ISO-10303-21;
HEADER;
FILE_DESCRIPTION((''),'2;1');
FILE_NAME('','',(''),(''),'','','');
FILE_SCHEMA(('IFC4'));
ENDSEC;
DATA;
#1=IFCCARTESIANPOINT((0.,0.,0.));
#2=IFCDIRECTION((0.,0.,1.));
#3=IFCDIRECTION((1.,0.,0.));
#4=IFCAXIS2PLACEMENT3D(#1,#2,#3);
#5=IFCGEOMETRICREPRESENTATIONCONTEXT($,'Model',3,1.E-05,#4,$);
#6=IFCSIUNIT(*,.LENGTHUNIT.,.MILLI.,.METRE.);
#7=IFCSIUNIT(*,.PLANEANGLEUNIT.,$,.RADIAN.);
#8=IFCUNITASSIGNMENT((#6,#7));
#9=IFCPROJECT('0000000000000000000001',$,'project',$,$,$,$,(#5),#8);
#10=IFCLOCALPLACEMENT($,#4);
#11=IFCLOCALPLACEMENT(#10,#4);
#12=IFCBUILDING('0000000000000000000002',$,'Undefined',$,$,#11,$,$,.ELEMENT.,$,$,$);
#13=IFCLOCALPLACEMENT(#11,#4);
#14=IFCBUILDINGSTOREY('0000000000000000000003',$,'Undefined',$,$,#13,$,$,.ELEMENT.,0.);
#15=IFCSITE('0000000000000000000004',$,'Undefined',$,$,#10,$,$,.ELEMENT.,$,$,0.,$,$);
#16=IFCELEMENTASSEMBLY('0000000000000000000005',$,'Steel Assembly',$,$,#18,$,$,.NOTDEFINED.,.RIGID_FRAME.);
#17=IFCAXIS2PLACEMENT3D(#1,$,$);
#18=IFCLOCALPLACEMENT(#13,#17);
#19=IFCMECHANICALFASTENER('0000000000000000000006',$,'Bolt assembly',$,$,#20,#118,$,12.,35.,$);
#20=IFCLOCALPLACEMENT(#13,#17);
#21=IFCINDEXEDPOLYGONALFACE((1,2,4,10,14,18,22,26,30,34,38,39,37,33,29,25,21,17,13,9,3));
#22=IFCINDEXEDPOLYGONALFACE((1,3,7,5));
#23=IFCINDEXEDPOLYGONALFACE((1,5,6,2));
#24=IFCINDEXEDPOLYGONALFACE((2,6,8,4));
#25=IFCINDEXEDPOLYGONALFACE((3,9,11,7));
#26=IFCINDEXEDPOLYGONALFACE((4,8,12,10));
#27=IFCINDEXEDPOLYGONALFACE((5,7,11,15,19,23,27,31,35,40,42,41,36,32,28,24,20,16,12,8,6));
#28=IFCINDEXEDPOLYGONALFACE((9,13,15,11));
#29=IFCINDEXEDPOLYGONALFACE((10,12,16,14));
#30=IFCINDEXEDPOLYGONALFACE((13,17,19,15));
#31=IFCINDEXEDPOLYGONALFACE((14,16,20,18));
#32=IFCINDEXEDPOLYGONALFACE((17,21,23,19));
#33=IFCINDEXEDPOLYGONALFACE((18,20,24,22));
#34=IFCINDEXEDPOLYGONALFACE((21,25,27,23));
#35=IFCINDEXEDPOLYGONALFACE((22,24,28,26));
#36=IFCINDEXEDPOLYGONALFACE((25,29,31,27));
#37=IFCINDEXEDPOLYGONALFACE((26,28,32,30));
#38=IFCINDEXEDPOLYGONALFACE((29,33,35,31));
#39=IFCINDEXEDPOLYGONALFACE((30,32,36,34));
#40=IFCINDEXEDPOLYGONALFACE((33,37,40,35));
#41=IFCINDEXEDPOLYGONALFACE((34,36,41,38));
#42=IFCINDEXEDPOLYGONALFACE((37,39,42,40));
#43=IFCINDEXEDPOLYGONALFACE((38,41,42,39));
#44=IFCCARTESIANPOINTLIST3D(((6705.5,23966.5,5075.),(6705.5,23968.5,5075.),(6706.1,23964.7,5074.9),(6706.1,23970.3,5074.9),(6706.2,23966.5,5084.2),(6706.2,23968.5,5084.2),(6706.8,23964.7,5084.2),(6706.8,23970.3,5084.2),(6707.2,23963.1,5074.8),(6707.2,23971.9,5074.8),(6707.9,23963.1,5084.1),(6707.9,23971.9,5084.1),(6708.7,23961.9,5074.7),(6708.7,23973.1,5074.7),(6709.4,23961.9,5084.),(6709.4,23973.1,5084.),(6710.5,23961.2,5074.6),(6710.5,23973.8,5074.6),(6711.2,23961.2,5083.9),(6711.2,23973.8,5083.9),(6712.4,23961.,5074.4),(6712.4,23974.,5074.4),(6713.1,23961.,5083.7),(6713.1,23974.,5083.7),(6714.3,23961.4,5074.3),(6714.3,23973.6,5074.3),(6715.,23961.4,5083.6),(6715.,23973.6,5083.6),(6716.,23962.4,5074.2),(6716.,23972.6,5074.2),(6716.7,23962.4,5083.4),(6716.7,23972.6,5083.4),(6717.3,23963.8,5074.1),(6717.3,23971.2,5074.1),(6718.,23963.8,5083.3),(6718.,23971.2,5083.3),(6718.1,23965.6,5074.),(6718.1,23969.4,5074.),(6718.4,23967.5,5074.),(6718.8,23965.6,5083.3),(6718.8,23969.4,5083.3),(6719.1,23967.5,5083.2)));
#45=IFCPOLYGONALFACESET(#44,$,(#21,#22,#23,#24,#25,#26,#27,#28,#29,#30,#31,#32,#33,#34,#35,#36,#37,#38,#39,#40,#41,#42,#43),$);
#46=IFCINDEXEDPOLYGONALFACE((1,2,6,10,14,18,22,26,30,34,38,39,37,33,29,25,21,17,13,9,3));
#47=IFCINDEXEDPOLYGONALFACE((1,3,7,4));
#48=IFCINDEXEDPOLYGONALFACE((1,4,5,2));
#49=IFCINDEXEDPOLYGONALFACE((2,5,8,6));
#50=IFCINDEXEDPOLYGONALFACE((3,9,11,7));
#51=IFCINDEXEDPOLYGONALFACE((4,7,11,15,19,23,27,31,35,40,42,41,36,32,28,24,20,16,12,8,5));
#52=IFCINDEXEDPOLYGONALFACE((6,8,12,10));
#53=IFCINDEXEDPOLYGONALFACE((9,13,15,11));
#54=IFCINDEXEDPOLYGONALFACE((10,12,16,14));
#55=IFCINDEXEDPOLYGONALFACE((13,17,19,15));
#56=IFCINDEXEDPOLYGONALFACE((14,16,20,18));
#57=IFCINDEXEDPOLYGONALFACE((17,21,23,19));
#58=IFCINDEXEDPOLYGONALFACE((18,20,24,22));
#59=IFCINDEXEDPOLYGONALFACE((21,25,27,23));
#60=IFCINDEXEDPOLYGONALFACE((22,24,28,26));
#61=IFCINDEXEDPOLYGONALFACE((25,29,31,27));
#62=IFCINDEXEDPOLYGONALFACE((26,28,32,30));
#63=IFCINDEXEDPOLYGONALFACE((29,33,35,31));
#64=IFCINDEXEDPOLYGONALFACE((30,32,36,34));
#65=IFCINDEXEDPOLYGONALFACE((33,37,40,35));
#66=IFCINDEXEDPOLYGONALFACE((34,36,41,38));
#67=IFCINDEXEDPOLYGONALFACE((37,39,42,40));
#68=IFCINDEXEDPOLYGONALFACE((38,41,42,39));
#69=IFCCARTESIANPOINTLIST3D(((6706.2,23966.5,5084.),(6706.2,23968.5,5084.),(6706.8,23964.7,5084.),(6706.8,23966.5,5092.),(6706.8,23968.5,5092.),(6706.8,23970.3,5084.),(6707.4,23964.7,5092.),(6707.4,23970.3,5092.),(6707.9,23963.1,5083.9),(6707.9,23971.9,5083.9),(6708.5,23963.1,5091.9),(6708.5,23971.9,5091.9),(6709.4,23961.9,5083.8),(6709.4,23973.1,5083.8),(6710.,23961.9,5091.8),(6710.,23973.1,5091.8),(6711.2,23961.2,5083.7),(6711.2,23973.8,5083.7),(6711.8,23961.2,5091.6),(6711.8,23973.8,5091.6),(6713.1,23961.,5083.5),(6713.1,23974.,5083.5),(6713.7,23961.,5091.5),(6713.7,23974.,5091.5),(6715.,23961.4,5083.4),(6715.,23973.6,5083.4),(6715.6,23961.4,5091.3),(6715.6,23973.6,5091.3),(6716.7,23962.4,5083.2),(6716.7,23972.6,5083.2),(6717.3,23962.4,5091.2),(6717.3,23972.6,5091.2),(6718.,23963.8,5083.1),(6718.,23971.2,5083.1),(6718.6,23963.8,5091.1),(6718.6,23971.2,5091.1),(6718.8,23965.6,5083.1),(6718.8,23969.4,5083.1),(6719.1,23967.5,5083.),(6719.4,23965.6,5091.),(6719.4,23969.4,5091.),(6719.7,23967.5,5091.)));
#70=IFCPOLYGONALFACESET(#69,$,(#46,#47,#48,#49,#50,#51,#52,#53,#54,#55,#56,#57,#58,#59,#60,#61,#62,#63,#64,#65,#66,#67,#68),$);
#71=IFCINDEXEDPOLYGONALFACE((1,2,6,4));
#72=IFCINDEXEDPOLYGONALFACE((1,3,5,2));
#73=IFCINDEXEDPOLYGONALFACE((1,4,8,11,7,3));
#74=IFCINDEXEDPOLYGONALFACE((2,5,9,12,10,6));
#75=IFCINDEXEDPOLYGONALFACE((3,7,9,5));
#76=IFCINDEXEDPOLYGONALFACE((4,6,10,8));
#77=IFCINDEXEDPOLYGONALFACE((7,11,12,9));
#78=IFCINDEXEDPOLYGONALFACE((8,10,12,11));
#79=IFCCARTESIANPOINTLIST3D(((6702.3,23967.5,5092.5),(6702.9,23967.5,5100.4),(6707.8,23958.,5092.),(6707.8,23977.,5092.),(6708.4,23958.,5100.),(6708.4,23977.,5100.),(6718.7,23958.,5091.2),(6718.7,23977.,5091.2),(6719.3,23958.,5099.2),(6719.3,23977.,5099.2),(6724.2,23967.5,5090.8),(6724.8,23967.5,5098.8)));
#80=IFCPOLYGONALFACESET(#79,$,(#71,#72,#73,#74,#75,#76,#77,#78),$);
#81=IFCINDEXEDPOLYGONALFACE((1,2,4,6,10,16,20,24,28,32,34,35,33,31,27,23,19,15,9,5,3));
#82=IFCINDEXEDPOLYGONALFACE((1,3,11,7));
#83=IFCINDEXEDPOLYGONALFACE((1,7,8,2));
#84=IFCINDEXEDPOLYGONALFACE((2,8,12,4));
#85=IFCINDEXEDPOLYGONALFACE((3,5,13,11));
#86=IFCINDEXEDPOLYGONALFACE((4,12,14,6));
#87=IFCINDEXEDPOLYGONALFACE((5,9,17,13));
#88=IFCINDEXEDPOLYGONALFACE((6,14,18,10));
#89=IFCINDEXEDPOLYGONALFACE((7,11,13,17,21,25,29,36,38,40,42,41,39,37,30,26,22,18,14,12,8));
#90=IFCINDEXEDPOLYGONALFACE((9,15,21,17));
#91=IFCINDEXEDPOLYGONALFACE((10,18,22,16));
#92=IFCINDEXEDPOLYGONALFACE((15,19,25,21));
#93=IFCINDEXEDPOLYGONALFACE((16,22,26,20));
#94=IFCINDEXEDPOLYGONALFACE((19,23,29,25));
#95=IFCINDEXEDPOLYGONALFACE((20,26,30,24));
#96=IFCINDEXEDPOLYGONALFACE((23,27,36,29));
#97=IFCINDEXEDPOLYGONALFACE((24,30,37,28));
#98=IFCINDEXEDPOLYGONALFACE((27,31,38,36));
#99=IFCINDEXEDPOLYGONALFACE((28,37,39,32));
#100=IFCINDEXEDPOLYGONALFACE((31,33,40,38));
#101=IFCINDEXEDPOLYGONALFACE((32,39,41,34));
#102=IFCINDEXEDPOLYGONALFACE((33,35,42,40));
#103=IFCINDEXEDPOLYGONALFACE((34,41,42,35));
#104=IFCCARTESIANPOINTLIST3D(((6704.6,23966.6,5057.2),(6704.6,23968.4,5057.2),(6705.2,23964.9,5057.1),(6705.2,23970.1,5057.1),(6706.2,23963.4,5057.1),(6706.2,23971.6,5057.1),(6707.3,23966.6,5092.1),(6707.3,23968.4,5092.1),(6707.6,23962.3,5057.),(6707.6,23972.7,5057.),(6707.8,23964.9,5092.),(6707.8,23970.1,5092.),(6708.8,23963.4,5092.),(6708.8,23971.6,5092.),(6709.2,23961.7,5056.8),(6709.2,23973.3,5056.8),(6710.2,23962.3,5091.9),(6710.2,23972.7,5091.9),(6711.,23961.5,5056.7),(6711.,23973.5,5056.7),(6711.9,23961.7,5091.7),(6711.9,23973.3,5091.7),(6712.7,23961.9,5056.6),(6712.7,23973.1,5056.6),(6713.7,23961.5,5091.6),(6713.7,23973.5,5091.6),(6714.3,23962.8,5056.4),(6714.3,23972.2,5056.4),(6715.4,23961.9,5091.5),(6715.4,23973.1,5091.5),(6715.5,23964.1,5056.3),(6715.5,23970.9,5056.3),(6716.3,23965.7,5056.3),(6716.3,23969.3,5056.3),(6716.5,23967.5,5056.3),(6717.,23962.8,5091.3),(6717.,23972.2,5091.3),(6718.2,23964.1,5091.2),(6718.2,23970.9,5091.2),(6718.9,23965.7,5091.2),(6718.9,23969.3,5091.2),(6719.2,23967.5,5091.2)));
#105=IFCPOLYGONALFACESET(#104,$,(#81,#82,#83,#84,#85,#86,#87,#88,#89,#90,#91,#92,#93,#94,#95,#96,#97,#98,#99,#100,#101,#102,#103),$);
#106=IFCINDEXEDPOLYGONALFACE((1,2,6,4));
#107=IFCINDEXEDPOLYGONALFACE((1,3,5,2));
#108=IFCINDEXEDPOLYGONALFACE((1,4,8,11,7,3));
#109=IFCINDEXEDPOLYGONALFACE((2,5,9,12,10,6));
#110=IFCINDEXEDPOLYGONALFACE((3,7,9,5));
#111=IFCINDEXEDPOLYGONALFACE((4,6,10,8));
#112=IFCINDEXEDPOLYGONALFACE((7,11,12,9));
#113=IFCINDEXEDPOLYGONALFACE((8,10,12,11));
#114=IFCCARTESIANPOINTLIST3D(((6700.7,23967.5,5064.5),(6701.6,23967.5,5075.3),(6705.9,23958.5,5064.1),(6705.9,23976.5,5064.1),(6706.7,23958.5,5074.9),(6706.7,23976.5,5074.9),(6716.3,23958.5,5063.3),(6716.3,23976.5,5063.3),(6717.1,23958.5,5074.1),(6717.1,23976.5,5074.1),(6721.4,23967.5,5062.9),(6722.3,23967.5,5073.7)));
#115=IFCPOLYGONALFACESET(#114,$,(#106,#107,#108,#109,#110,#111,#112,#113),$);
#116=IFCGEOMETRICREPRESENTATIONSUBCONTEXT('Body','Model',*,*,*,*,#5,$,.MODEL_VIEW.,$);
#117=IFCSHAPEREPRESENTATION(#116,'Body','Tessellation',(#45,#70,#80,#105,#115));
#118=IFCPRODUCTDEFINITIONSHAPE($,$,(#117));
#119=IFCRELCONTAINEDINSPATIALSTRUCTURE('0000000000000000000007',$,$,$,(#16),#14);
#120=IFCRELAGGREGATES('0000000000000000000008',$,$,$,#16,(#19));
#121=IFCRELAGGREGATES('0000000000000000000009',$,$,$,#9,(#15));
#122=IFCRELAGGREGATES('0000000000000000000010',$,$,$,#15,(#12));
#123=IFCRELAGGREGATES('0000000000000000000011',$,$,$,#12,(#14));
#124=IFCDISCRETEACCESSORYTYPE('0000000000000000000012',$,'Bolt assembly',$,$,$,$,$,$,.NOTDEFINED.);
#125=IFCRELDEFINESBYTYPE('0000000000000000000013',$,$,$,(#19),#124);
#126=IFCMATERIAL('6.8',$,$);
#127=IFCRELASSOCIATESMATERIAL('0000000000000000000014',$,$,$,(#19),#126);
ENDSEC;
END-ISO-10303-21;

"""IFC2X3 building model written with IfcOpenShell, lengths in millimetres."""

from ifc_helpers import new_model, si_unit, frame, origin_with_axes, origin_2d_with_axis, place, context, subcontext, project, spatial, polyline, circle, outline, extrude, source, transform, mapped, material, type_object, element, aggregate, save


model = new_model("IFC2X3")

# Units and contexts
model_context = context("Model", 3, precision=1e-05, world=origin_with_axes())
body_context = subcontext(model_context, "Body", "Model", "MODEL_VIEW")
ifc_project = project(units=[si_unit("LENGTHUNIT", "METRE", prefix="MILLI"), si_unit("PLANEANGLEUNIT", "RADIAN")], contexts=[model_context])

# Site, building, storey
site_placement = place(None, origin_with_axes())
site = spatial("IfcSite", under=ifc_project, at=site_placement, Name="Undefined", CompositionType="ELEMENT", RefElevation=0.0)
building_placement = place(site_placement, origin_with_axes())
building = spatial("IfcBuilding", under=site, at=building_placement, Name="Undefined", CompositionType="ELEMENT")
storey_placement = place(building_placement, origin_with_axes())
storey = spatial("IfcBuildingStorey", under=building, at=storey_placement, Name="Undefined", CompositionType="ELEMENT", Elevation=0.0)

# Element assembly, mechanical fastener
assembly_1_placement = place(storey_placement, origin_with_axes())
assembly_1 = element("IfcElementAssembly", 1, at=assembly_1_placement, inside=storey, Name="Steel Assembly", AssemblyPlace="NOTDEFINED", PredefinedType="RIGID_FRAME")
ifc_material_1 = material(Name="6.8")
discrete_accessory_type_1 = type_object("IfcDiscreteAccessoryType", Name="Bolt assembly")
shared_shape_1 = source(origin_with_axes(), body_context, "Body", "SweptSolid", [
    extrude(circle(Radius=6.5, at=origin_2d_with_axis()), frame((0.0, -0.1, 0.0), z_axis=(0.0, 1.0, 0.0), x_axis=(1.0, 0.0, 0.0)), (0.0, 0.0, 1.0), 9.3),
    extrude(circle(Radius=6.5, at=origin_2d_with_axis()), frame((0.0, -7.9, 0.0), z_axis=(0.0, 1.0, 0.0), x_axis=(1.0, 0.0, 0.0)), (0.0, 0.0, 1.0), 8.0),
    extrude(outline(polyline([(11.0, 0.0), (5.5, 9.5), (-5.5, 9.5), (-11.0, 0.0), (-5.5, -9.5), (5.5, -9.5), (11.0, 0.0)])), frame((0.0, -16.0, 0.0), z_axis=(0.0, 1.0, 0.0), x_axis=(1.0, 0.0, 0.0)), (0.0, 0.0, 1.0), 8.0),
    extrude(circle(Radius=6.0, at=origin_2d_with_axis()), frame((0.0, -8.0, 0.0), z_axis=(0.0, 1.0, 0.0), x_axis=(1.0, 0.0, 0.0)), (0.0, 0.0, 1.0), 35.0),
    extrude(outline(polyline([(10.4, 0.0), (5.2, 9.0), (-5.2, 9.0), (-10.4, 0.0), (-5.2, -9.0), (5.2, -9.0), (10.4, 0.0)])), frame((0.0, 9.2, 0.0), z_axis=(0.0, 1.0, 0.0), x_axis=(1.0, 0.0, 0.0)), (0.0, 0.0, 1.0), 10.8),
])
mechanical_fastener_1_placement = place(assembly_1_placement, frame((6712.6, 23967.5, 5083.6), z_axis=(0.0, 1.0, 0.0), x_axis=(0.997054, 0.0, -0.076696)))
mechanical_fastener_1 = element("IfcMechanicalFastener", 2, at=mechanical_fastener_1_placement, type_object=discrete_accessory_type_1, material=ifc_material_1, Name="Bolt assembly", NominalDiameter=12.0, NominalLength=35.0, context=body_context, shape_type="MappedRepresentation", body=[
    mapped(shared_shape_1, transform((0.0, 0.0, 0.0))),
])
aggregate(assembly_1, [mechanical_fastener_1])

save(model, "model.ifc")
